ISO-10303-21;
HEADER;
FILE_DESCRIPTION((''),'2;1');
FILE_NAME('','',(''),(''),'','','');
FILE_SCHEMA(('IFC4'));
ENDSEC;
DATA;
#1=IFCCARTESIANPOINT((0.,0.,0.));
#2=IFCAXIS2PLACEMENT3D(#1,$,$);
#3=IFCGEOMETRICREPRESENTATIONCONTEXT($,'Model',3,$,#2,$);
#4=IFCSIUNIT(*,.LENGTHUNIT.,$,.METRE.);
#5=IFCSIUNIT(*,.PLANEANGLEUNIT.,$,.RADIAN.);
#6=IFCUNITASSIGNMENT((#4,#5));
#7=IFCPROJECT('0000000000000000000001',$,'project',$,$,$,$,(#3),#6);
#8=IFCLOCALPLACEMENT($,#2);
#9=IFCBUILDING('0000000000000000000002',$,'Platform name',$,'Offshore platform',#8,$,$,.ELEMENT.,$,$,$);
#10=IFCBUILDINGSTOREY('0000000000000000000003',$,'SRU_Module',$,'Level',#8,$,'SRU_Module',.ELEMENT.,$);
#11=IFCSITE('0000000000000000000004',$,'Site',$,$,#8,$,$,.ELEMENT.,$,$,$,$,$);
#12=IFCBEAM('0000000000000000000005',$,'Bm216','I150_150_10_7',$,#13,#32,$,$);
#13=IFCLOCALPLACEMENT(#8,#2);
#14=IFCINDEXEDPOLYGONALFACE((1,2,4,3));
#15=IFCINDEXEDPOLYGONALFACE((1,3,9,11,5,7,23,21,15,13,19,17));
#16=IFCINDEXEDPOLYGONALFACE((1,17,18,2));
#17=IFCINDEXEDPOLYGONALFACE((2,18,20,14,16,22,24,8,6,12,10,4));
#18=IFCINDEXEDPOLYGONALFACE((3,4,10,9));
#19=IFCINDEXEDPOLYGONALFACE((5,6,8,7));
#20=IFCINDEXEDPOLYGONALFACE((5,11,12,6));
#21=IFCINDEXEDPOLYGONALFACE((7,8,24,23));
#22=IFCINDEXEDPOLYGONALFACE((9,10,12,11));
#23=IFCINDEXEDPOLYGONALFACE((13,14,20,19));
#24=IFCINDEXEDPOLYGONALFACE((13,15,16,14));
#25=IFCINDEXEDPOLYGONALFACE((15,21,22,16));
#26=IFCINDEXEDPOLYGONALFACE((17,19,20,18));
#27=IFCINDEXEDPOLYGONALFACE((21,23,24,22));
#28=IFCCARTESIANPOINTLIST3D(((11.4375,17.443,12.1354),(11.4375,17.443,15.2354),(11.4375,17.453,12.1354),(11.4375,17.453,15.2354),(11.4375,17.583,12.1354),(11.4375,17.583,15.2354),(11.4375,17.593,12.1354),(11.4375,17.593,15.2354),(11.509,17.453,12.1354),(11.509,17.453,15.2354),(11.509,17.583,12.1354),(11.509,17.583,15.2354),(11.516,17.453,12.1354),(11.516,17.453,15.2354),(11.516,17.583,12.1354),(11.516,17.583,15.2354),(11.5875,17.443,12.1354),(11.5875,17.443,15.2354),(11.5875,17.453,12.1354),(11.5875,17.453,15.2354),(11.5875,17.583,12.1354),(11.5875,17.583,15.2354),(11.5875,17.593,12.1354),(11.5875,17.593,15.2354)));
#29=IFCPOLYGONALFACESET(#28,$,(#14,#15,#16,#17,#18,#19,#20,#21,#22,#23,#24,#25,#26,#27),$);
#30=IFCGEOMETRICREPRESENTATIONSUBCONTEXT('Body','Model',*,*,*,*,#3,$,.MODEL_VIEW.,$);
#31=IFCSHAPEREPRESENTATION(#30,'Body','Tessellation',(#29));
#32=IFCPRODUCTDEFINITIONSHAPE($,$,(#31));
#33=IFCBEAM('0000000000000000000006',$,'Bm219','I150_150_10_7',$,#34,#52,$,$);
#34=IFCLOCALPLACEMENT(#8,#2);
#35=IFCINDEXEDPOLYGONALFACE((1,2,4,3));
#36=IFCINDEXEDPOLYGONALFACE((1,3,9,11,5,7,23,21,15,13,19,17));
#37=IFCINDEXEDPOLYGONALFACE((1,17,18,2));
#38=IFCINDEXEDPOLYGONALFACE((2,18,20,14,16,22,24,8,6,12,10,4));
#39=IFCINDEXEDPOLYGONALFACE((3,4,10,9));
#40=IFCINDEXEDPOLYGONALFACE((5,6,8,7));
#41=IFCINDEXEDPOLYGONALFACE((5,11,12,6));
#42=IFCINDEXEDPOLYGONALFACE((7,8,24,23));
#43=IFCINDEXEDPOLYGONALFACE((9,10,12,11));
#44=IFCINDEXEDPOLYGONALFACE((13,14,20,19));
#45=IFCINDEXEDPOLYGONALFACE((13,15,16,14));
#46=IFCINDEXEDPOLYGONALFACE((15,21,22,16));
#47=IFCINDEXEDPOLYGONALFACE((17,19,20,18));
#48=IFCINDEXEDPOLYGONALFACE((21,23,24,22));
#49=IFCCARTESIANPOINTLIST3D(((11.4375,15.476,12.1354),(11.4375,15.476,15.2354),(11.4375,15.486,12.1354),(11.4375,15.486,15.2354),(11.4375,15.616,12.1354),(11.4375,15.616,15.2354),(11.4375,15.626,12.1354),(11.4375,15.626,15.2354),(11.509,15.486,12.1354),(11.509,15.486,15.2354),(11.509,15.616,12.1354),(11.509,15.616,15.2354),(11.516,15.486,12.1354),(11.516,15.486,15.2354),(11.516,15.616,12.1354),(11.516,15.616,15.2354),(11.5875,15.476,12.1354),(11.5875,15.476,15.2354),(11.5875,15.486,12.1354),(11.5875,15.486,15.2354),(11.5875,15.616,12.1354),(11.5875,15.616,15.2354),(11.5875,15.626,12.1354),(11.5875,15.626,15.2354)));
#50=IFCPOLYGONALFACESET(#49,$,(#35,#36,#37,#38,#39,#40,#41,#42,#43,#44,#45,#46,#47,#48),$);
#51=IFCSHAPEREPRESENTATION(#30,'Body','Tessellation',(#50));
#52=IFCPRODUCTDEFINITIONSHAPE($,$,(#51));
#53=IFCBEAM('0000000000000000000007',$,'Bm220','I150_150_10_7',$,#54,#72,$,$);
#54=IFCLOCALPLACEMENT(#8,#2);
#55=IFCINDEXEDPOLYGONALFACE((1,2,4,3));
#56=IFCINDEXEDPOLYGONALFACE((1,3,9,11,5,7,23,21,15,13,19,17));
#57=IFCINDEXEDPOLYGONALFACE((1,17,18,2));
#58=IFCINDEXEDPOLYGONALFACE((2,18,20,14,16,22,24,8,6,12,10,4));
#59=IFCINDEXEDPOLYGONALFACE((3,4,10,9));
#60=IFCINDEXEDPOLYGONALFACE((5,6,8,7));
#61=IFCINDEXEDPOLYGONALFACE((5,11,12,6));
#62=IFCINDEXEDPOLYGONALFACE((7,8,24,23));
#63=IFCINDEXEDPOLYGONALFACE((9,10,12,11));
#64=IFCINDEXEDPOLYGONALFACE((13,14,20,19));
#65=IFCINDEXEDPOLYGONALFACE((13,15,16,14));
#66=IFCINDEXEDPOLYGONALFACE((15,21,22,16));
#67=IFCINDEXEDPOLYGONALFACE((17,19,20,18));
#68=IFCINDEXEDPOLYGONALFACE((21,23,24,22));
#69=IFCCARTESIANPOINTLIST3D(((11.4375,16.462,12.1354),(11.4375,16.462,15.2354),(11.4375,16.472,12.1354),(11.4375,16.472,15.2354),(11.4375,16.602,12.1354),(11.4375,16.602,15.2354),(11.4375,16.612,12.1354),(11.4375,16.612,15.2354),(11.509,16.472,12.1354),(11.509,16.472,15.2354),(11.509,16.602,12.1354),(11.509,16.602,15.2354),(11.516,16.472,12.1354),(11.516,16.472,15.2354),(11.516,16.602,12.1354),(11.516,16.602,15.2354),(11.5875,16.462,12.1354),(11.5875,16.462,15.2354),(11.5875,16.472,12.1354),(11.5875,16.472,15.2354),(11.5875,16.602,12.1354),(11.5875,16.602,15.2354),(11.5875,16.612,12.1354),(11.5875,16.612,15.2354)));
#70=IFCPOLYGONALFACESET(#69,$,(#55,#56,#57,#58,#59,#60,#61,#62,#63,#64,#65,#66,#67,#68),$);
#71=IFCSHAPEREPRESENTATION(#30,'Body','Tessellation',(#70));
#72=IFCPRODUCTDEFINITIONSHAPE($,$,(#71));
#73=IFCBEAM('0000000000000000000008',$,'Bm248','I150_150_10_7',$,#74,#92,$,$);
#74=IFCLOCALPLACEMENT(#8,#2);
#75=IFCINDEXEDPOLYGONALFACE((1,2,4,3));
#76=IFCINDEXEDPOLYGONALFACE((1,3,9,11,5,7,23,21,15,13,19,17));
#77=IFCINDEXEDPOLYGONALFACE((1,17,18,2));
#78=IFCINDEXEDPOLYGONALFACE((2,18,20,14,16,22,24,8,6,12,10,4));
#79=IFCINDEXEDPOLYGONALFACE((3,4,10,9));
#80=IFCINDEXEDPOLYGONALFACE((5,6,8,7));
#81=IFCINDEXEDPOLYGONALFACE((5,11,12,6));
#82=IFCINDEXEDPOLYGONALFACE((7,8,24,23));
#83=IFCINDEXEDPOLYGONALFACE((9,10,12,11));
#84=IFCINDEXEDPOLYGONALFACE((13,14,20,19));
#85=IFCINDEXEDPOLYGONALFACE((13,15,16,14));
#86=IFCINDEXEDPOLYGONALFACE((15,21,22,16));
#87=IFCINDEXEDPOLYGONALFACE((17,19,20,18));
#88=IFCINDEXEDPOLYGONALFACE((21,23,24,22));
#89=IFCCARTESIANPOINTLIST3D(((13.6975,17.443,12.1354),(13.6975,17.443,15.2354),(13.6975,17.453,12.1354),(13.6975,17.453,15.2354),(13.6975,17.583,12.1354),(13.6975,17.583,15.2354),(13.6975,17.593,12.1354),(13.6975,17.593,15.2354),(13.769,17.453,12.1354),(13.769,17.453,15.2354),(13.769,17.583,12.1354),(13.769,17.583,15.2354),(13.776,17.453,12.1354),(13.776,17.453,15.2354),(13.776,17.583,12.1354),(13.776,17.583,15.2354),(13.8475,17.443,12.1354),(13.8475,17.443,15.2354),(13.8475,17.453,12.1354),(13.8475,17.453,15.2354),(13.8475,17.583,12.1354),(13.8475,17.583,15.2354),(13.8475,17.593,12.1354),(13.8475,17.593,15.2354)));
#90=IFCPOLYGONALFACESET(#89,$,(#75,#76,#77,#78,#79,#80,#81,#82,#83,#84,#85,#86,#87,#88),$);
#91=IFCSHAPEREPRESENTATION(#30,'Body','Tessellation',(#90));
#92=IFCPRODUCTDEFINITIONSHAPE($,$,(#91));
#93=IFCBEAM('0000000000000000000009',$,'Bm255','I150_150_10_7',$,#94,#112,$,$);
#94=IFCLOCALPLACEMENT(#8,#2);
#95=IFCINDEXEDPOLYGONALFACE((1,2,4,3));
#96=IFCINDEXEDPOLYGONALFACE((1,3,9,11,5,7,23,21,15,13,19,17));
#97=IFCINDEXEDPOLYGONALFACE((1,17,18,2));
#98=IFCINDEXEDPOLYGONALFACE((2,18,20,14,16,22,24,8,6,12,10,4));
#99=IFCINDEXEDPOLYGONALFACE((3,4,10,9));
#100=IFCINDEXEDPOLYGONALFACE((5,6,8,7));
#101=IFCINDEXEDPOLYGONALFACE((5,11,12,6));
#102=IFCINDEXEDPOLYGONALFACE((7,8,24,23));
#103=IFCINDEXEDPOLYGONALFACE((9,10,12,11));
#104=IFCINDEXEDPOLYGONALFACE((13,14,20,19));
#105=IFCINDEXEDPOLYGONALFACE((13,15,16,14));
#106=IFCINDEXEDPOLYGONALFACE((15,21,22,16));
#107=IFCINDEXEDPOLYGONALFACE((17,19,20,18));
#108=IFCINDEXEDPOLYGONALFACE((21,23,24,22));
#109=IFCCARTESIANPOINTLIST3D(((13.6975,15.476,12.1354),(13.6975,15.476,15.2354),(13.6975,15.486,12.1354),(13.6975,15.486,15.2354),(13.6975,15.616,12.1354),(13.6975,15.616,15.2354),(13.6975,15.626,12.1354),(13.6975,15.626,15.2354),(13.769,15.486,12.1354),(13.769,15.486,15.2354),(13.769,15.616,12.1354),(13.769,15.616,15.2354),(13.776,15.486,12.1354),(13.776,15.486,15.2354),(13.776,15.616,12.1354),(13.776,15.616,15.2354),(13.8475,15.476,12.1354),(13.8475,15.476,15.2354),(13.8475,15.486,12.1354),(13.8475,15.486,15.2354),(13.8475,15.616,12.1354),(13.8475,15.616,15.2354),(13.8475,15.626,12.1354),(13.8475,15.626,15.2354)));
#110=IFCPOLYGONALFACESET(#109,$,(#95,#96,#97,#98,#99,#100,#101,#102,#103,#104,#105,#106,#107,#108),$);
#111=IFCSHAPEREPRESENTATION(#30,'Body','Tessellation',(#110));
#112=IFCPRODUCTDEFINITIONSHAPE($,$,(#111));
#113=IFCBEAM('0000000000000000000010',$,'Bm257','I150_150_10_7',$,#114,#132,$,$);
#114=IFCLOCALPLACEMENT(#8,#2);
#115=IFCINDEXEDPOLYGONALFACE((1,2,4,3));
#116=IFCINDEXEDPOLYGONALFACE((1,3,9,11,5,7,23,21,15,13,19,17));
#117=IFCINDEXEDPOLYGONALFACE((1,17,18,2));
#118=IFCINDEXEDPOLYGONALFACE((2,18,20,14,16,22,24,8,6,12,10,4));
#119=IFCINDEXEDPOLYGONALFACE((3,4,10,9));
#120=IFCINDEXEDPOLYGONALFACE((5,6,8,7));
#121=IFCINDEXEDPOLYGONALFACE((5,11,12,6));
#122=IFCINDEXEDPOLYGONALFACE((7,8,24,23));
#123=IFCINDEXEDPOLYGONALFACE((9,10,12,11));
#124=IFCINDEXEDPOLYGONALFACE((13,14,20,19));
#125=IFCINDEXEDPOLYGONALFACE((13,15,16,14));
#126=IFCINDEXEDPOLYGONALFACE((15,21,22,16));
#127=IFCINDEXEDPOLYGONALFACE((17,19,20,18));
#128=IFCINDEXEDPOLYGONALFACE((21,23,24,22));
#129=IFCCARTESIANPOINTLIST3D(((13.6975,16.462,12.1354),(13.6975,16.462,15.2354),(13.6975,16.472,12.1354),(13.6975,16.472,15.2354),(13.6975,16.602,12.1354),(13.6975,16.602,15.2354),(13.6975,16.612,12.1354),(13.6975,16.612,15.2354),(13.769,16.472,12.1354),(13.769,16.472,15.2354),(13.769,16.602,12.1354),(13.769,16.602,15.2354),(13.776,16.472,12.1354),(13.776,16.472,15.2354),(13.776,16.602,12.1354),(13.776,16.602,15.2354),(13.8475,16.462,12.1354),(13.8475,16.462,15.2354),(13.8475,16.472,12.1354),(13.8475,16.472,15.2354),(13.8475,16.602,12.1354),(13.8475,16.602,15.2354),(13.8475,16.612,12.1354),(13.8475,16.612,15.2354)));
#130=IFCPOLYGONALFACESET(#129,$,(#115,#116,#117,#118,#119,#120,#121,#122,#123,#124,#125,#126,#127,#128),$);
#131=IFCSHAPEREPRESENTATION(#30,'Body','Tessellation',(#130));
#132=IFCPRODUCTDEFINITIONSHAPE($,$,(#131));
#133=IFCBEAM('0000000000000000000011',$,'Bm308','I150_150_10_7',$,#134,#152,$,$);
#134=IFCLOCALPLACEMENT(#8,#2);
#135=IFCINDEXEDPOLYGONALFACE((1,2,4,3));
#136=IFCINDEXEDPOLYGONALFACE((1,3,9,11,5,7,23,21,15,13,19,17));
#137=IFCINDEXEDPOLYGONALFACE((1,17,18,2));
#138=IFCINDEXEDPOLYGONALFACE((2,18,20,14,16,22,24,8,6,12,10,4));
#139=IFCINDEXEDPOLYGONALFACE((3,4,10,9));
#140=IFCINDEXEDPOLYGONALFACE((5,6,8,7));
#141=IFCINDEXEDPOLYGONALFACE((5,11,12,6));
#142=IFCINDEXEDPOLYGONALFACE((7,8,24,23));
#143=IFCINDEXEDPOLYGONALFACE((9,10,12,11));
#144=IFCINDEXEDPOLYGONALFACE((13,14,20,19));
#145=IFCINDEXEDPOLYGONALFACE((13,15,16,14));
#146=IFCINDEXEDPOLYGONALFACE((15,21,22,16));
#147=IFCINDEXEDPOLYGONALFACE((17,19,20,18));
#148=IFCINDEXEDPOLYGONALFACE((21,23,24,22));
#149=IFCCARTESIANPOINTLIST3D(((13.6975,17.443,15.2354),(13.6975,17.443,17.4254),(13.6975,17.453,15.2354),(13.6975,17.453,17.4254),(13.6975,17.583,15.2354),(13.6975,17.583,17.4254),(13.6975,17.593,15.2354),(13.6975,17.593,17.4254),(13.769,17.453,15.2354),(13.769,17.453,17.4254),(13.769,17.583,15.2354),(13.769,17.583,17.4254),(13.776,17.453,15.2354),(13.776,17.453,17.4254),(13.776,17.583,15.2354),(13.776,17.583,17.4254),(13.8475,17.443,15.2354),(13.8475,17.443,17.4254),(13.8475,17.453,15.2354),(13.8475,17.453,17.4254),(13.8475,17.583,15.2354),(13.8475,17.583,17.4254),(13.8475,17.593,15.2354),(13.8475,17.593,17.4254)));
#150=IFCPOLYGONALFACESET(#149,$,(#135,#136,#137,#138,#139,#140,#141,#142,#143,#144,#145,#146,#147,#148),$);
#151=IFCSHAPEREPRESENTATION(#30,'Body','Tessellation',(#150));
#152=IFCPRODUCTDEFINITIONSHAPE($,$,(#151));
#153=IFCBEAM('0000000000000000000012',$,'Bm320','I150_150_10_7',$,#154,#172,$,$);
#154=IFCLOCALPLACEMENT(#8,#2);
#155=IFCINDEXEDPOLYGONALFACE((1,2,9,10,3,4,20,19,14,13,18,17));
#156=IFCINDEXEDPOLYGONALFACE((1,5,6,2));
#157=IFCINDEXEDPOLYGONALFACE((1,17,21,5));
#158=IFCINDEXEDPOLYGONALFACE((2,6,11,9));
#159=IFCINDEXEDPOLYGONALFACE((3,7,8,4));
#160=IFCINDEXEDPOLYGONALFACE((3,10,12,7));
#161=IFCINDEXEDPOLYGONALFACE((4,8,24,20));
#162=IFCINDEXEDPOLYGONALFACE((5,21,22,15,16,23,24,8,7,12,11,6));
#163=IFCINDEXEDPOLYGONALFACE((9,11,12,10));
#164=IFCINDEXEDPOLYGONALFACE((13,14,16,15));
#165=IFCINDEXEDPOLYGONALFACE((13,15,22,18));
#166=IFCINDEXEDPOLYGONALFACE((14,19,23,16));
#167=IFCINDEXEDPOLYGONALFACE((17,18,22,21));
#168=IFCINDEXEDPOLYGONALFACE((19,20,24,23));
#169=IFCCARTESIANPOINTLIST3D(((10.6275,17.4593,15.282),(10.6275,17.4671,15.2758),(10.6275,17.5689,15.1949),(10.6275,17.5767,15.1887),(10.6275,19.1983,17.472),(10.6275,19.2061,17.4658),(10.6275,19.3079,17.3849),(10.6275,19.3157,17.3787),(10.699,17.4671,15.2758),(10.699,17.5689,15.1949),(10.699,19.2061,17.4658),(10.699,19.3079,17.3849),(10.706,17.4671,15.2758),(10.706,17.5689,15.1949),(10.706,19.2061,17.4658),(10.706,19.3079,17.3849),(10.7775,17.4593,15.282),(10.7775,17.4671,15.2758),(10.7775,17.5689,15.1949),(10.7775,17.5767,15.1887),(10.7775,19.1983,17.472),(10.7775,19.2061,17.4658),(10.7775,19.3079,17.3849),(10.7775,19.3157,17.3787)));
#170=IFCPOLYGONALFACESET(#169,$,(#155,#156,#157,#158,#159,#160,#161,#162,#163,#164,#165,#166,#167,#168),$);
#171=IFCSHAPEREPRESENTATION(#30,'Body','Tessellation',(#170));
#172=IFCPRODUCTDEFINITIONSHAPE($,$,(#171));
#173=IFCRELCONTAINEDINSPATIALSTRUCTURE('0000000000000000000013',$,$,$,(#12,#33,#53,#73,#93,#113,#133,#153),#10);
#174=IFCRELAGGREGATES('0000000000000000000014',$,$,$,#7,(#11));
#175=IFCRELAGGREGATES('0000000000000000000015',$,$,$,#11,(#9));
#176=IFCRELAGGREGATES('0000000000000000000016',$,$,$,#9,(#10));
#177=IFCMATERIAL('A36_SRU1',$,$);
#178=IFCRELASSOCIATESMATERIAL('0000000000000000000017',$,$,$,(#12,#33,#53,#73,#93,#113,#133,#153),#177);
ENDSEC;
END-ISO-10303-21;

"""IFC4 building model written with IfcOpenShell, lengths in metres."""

from ifc_helpers import new_model, si_unit, frame, origin, origin_with_axes, origin_2d, place, context, subcontext, project, spatial, i_section, extrude, source, transform, mapped, material, element, save


model = new_model("IFC4")

# Units and contexts
model_context = context("Model", 3, world=origin())
body_context = subcontext(model_context, "Body", "Model", "MODEL_VIEW")
ifc_project = project(units=[si_unit("LENGTHUNIT", "METRE"), si_unit("PLANEANGLEUNIT", "RADIAN")], contexts=[model_context])

# Site, building, storey
placement_1 = place(None, origin())
site = spatial("IfcSite", under=ifc_project, at=placement_1, Name="Site", CompositionType="ELEMENT")
building = spatial("IfcBuilding", under=site, at=placement_1, Name="Platform name", ObjectType="Offshore platform", CompositionType="ELEMENT")
storey = spatial("IfcBuildingStorey", under=building, at=placement_1, Name="SRU_Module", ObjectType="Level", LongName="SRU_Module", CompositionType="ELEMENT")

# Beams
ifc_material_1 = material(Name="A36_SRU1")
shared_shape_1 = source(origin(), body_context, "Body", "SweptSolid", [
    extrude(i_section(OverallWidth=0.15, OverallDepth=0.15, WebThickness=0.007, FlangeThickness=0.01, FilletRadius=0.0, at=origin_2d()), origin_with_axes(), (0.0, 0.0, 1.0), 3.1),
])
placement_2 = place(None, origin())
placement_3 = place(placement_2, origin())
placement_4 = place(placement_3, origin())
beam_1_placement = place(placement_4, frame((11.5125, 17.518, 12.1354)))
element("IfcBeam", 1, at=beam_1_placement, inside=storey, material=ifc_material_1, Name="Bm216", Description="I150_150_10_7", context=body_context, shape_type="MappedRepresentation", body=[
    mapped(shared_shape_1, transform((0.0, 0.0, 0.0), scale=1.0)),
])
shared_shape_2 = source(origin(), body_context, "Body", "SweptSolid", [
    extrude(i_section(OverallWidth=0.15, OverallDepth=0.15, WebThickness=0.007, FlangeThickness=0.01, FilletRadius=0.0, at=origin_2d()), origin_with_axes(), (0.0, 0.0, 1.0), 3.1),
])
placement_5 = place(None, origin())
placement_6 = place(placement_5, origin())
placement_7 = place(placement_6, origin())
beam_2_placement = place(placement_7, frame((11.5125, 15.551, 12.1354)))
element("IfcBeam", 2, at=beam_2_placement, inside=storey, material=ifc_material_1, Name="Bm219", Description="I150_150_10_7", context=body_context, shape_type="MappedRepresentation", body=[
    mapped(shared_shape_2, transform((0.0, 0.0, 0.0), scale=1.0)),
])
shared_shape_3 = source(origin(), body_context, "Body", "SweptSolid", [
    extrude(i_section(OverallWidth=0.15, OverallDepth=0.15, WebThickness=0.007, FlangeThickness=0.01, FilletRadius=0.0, at=origin_2d()), origin_with_axes(), (0.0, 0.0, 1.0), 3.1),
])
placement_8 = place(None, origin())
placement_9 = place(placement_8, origin())
placement_10 = place(placement_9, origin())
beam_3_placement = place(placement_10, frame((11.5125, 16.537, 12.1354)))
element("IfcBeam", 3, at=beam_3_placement, inside=storey, material=ifc_material_1, Name="Bm220", Description="I150_150_10_7", context=body_context, shape_type="MappedRepresentation", body=[
    mapped(shared_shape_3, transform((0.0, 0.0, 0.0), scale=1.0)),
])
shared_shape_4 = source(origin(), body_context, "Body", "SweptSolid", [
    extrude(i_section(OverallWidth=0.15, OverallDepth=0.15, WebThickness=0.007, FlangeThickness=0.01, FilletRadius=0.0, at=origin_2d()), origin_with_axes(), (0.0, 0.0, 1.0), 3.1),
])
placement_11 = place(None, origin())
placement_12 = place(placement_11, origin())
placement_13 = place(placement_12, origin())
beam_4_placement = place(placement_13, frame((13.7725, 17.518, 12.1354)))
element("IfcBeam", 4, at=beam_4_placement, inside=storey, material=ifc_material_1, Name="Bm248", Description="I150_150_10_7", context=body_context, shape_type="MappedRepresentation", body=[
    mapped(shared_shape_4, transform((0.0, 0.0, 0.0), scale=1.0)),
])
shared_shape_5 = source(origin(), body_context, "Body", "SweptSolid", [
    extrude(i_section(OverallWidth=0.15, OverallDepth=0.15, WebThickness=0.007, FlangeThickness=0.01, FilletRadius=0.0, at=origin_2d()), origin_with_axes(), (0.0, 0.0, 1.0), 3.1),
])
placement_14 = place(None, origin())
placement_15 = place(placement_14, origin())
placement_16 = place(placement_15, origin())
beam_5_placement = place(placement_16, frame((13.7725, 15.551, 12.1354)))
element("IfcBeam", 5, at=beam_5_placement, inside=storey, material=ifc_material_1, Name="Bm255", Description="I150_150_10_7", context=body_context, shape_type="MappedRepresentation", body=[
    mapped(shared_shape_5, transform((0.0, 0.0, 0.0), scale=1.0)),
])
shared_shape_6 = source(origin(), body_context, "Body", "SweptSolid", [
    extrude(i_section(OverallWidth=0.15, OverallDepth=0.15, WebThickness=0.007, FlangeThickness=0.01, FilletRadius=0.0, at=origin_2d()), origin_with_axes(), (0.0, 0.0, 1.0), 3.1),
])
placement_17 = place(None, origin())
placement_18 = place(placement_17, origin())
placement_19 = place(placement_18, origin())
beam_6_placement = place(placement_19, frame((13.7725, 16.537, 12.1354)))
element("IfcBeam", 6, at=beam_6_placement, inside=storey, material=ifc_material_1, Name="Bm257", Description="I150_150_10_7", context=body_context, shape_type="MappedRepresentation", body=[
    mapped(shared_shape_6, transform((0.0, 0.0, 0.0), scale=1.0)),
])
shared_shape_7 = source(origin(), body_context, "Body", "SweptSolid", [
    extrude(i_section(OverallWidth=0.15, OverallDepth=0.15, WebThickness=0.007, FlangeThickness=0.01, FilletRadius=0.0, at=origin_2d()), origin_with_axes(), (0.0, 0.0, 1.0), 2.19),
])
placement_20 = place(None, origin())
placement_21 = place(placement_20, origin())
placement_22 = place(placement_21, origin())
beam_7_placement = place(placement_22, frame((13.7725, 17.518, 15.2354)))
element("IfcBeam", 7, at=beam_7_placement, inside=storey, material=ifc_material_1, Name="Bm308", Description="I150_150_10_7", context=body_context, shape_type="MappedRepresentation", body=[
    mapped(shared_shape_7, transform((0.0, 0.0, 0.0), scale=1.0)),
])
shared_shape_8 = source(origin(), body_context, "Body", "SweptSolid", [
    extrude(i_section(OverallWidth=0.15, OverallDepth=0.15, WebThickness=0.007, FlangeThickness=0.01, FilletRadius=0.0, at=origin_2d()), frame((0.0, 0.0, 0.0), z_axis=(0.0, 0.621856, 0.783131), x_axis=(-1.0, 0.0, 0.0)), (0.0, 0.0, 1.0), 2.7965),
])
placement_23 = place(None, origin())
placement_24 = place(placement_23, origin())
placement_25 = place(placement_24, origin())
beam_8_placement = place(placement_25, frame((10.7025, 17.518, 15.2354)))
element("IfcBeam", 8, at=beam_8_placement, inside=storey, material=ifc_material_1, Name="Bm320", Description="I150_150_10_7", context=body_context, shape_type="MappedRepresentation", body=[
    mapped(shared_shape_8, transform((0.0, 0.0, 0.0), scale=1.0)),
])

save(model, "model.ifc")
